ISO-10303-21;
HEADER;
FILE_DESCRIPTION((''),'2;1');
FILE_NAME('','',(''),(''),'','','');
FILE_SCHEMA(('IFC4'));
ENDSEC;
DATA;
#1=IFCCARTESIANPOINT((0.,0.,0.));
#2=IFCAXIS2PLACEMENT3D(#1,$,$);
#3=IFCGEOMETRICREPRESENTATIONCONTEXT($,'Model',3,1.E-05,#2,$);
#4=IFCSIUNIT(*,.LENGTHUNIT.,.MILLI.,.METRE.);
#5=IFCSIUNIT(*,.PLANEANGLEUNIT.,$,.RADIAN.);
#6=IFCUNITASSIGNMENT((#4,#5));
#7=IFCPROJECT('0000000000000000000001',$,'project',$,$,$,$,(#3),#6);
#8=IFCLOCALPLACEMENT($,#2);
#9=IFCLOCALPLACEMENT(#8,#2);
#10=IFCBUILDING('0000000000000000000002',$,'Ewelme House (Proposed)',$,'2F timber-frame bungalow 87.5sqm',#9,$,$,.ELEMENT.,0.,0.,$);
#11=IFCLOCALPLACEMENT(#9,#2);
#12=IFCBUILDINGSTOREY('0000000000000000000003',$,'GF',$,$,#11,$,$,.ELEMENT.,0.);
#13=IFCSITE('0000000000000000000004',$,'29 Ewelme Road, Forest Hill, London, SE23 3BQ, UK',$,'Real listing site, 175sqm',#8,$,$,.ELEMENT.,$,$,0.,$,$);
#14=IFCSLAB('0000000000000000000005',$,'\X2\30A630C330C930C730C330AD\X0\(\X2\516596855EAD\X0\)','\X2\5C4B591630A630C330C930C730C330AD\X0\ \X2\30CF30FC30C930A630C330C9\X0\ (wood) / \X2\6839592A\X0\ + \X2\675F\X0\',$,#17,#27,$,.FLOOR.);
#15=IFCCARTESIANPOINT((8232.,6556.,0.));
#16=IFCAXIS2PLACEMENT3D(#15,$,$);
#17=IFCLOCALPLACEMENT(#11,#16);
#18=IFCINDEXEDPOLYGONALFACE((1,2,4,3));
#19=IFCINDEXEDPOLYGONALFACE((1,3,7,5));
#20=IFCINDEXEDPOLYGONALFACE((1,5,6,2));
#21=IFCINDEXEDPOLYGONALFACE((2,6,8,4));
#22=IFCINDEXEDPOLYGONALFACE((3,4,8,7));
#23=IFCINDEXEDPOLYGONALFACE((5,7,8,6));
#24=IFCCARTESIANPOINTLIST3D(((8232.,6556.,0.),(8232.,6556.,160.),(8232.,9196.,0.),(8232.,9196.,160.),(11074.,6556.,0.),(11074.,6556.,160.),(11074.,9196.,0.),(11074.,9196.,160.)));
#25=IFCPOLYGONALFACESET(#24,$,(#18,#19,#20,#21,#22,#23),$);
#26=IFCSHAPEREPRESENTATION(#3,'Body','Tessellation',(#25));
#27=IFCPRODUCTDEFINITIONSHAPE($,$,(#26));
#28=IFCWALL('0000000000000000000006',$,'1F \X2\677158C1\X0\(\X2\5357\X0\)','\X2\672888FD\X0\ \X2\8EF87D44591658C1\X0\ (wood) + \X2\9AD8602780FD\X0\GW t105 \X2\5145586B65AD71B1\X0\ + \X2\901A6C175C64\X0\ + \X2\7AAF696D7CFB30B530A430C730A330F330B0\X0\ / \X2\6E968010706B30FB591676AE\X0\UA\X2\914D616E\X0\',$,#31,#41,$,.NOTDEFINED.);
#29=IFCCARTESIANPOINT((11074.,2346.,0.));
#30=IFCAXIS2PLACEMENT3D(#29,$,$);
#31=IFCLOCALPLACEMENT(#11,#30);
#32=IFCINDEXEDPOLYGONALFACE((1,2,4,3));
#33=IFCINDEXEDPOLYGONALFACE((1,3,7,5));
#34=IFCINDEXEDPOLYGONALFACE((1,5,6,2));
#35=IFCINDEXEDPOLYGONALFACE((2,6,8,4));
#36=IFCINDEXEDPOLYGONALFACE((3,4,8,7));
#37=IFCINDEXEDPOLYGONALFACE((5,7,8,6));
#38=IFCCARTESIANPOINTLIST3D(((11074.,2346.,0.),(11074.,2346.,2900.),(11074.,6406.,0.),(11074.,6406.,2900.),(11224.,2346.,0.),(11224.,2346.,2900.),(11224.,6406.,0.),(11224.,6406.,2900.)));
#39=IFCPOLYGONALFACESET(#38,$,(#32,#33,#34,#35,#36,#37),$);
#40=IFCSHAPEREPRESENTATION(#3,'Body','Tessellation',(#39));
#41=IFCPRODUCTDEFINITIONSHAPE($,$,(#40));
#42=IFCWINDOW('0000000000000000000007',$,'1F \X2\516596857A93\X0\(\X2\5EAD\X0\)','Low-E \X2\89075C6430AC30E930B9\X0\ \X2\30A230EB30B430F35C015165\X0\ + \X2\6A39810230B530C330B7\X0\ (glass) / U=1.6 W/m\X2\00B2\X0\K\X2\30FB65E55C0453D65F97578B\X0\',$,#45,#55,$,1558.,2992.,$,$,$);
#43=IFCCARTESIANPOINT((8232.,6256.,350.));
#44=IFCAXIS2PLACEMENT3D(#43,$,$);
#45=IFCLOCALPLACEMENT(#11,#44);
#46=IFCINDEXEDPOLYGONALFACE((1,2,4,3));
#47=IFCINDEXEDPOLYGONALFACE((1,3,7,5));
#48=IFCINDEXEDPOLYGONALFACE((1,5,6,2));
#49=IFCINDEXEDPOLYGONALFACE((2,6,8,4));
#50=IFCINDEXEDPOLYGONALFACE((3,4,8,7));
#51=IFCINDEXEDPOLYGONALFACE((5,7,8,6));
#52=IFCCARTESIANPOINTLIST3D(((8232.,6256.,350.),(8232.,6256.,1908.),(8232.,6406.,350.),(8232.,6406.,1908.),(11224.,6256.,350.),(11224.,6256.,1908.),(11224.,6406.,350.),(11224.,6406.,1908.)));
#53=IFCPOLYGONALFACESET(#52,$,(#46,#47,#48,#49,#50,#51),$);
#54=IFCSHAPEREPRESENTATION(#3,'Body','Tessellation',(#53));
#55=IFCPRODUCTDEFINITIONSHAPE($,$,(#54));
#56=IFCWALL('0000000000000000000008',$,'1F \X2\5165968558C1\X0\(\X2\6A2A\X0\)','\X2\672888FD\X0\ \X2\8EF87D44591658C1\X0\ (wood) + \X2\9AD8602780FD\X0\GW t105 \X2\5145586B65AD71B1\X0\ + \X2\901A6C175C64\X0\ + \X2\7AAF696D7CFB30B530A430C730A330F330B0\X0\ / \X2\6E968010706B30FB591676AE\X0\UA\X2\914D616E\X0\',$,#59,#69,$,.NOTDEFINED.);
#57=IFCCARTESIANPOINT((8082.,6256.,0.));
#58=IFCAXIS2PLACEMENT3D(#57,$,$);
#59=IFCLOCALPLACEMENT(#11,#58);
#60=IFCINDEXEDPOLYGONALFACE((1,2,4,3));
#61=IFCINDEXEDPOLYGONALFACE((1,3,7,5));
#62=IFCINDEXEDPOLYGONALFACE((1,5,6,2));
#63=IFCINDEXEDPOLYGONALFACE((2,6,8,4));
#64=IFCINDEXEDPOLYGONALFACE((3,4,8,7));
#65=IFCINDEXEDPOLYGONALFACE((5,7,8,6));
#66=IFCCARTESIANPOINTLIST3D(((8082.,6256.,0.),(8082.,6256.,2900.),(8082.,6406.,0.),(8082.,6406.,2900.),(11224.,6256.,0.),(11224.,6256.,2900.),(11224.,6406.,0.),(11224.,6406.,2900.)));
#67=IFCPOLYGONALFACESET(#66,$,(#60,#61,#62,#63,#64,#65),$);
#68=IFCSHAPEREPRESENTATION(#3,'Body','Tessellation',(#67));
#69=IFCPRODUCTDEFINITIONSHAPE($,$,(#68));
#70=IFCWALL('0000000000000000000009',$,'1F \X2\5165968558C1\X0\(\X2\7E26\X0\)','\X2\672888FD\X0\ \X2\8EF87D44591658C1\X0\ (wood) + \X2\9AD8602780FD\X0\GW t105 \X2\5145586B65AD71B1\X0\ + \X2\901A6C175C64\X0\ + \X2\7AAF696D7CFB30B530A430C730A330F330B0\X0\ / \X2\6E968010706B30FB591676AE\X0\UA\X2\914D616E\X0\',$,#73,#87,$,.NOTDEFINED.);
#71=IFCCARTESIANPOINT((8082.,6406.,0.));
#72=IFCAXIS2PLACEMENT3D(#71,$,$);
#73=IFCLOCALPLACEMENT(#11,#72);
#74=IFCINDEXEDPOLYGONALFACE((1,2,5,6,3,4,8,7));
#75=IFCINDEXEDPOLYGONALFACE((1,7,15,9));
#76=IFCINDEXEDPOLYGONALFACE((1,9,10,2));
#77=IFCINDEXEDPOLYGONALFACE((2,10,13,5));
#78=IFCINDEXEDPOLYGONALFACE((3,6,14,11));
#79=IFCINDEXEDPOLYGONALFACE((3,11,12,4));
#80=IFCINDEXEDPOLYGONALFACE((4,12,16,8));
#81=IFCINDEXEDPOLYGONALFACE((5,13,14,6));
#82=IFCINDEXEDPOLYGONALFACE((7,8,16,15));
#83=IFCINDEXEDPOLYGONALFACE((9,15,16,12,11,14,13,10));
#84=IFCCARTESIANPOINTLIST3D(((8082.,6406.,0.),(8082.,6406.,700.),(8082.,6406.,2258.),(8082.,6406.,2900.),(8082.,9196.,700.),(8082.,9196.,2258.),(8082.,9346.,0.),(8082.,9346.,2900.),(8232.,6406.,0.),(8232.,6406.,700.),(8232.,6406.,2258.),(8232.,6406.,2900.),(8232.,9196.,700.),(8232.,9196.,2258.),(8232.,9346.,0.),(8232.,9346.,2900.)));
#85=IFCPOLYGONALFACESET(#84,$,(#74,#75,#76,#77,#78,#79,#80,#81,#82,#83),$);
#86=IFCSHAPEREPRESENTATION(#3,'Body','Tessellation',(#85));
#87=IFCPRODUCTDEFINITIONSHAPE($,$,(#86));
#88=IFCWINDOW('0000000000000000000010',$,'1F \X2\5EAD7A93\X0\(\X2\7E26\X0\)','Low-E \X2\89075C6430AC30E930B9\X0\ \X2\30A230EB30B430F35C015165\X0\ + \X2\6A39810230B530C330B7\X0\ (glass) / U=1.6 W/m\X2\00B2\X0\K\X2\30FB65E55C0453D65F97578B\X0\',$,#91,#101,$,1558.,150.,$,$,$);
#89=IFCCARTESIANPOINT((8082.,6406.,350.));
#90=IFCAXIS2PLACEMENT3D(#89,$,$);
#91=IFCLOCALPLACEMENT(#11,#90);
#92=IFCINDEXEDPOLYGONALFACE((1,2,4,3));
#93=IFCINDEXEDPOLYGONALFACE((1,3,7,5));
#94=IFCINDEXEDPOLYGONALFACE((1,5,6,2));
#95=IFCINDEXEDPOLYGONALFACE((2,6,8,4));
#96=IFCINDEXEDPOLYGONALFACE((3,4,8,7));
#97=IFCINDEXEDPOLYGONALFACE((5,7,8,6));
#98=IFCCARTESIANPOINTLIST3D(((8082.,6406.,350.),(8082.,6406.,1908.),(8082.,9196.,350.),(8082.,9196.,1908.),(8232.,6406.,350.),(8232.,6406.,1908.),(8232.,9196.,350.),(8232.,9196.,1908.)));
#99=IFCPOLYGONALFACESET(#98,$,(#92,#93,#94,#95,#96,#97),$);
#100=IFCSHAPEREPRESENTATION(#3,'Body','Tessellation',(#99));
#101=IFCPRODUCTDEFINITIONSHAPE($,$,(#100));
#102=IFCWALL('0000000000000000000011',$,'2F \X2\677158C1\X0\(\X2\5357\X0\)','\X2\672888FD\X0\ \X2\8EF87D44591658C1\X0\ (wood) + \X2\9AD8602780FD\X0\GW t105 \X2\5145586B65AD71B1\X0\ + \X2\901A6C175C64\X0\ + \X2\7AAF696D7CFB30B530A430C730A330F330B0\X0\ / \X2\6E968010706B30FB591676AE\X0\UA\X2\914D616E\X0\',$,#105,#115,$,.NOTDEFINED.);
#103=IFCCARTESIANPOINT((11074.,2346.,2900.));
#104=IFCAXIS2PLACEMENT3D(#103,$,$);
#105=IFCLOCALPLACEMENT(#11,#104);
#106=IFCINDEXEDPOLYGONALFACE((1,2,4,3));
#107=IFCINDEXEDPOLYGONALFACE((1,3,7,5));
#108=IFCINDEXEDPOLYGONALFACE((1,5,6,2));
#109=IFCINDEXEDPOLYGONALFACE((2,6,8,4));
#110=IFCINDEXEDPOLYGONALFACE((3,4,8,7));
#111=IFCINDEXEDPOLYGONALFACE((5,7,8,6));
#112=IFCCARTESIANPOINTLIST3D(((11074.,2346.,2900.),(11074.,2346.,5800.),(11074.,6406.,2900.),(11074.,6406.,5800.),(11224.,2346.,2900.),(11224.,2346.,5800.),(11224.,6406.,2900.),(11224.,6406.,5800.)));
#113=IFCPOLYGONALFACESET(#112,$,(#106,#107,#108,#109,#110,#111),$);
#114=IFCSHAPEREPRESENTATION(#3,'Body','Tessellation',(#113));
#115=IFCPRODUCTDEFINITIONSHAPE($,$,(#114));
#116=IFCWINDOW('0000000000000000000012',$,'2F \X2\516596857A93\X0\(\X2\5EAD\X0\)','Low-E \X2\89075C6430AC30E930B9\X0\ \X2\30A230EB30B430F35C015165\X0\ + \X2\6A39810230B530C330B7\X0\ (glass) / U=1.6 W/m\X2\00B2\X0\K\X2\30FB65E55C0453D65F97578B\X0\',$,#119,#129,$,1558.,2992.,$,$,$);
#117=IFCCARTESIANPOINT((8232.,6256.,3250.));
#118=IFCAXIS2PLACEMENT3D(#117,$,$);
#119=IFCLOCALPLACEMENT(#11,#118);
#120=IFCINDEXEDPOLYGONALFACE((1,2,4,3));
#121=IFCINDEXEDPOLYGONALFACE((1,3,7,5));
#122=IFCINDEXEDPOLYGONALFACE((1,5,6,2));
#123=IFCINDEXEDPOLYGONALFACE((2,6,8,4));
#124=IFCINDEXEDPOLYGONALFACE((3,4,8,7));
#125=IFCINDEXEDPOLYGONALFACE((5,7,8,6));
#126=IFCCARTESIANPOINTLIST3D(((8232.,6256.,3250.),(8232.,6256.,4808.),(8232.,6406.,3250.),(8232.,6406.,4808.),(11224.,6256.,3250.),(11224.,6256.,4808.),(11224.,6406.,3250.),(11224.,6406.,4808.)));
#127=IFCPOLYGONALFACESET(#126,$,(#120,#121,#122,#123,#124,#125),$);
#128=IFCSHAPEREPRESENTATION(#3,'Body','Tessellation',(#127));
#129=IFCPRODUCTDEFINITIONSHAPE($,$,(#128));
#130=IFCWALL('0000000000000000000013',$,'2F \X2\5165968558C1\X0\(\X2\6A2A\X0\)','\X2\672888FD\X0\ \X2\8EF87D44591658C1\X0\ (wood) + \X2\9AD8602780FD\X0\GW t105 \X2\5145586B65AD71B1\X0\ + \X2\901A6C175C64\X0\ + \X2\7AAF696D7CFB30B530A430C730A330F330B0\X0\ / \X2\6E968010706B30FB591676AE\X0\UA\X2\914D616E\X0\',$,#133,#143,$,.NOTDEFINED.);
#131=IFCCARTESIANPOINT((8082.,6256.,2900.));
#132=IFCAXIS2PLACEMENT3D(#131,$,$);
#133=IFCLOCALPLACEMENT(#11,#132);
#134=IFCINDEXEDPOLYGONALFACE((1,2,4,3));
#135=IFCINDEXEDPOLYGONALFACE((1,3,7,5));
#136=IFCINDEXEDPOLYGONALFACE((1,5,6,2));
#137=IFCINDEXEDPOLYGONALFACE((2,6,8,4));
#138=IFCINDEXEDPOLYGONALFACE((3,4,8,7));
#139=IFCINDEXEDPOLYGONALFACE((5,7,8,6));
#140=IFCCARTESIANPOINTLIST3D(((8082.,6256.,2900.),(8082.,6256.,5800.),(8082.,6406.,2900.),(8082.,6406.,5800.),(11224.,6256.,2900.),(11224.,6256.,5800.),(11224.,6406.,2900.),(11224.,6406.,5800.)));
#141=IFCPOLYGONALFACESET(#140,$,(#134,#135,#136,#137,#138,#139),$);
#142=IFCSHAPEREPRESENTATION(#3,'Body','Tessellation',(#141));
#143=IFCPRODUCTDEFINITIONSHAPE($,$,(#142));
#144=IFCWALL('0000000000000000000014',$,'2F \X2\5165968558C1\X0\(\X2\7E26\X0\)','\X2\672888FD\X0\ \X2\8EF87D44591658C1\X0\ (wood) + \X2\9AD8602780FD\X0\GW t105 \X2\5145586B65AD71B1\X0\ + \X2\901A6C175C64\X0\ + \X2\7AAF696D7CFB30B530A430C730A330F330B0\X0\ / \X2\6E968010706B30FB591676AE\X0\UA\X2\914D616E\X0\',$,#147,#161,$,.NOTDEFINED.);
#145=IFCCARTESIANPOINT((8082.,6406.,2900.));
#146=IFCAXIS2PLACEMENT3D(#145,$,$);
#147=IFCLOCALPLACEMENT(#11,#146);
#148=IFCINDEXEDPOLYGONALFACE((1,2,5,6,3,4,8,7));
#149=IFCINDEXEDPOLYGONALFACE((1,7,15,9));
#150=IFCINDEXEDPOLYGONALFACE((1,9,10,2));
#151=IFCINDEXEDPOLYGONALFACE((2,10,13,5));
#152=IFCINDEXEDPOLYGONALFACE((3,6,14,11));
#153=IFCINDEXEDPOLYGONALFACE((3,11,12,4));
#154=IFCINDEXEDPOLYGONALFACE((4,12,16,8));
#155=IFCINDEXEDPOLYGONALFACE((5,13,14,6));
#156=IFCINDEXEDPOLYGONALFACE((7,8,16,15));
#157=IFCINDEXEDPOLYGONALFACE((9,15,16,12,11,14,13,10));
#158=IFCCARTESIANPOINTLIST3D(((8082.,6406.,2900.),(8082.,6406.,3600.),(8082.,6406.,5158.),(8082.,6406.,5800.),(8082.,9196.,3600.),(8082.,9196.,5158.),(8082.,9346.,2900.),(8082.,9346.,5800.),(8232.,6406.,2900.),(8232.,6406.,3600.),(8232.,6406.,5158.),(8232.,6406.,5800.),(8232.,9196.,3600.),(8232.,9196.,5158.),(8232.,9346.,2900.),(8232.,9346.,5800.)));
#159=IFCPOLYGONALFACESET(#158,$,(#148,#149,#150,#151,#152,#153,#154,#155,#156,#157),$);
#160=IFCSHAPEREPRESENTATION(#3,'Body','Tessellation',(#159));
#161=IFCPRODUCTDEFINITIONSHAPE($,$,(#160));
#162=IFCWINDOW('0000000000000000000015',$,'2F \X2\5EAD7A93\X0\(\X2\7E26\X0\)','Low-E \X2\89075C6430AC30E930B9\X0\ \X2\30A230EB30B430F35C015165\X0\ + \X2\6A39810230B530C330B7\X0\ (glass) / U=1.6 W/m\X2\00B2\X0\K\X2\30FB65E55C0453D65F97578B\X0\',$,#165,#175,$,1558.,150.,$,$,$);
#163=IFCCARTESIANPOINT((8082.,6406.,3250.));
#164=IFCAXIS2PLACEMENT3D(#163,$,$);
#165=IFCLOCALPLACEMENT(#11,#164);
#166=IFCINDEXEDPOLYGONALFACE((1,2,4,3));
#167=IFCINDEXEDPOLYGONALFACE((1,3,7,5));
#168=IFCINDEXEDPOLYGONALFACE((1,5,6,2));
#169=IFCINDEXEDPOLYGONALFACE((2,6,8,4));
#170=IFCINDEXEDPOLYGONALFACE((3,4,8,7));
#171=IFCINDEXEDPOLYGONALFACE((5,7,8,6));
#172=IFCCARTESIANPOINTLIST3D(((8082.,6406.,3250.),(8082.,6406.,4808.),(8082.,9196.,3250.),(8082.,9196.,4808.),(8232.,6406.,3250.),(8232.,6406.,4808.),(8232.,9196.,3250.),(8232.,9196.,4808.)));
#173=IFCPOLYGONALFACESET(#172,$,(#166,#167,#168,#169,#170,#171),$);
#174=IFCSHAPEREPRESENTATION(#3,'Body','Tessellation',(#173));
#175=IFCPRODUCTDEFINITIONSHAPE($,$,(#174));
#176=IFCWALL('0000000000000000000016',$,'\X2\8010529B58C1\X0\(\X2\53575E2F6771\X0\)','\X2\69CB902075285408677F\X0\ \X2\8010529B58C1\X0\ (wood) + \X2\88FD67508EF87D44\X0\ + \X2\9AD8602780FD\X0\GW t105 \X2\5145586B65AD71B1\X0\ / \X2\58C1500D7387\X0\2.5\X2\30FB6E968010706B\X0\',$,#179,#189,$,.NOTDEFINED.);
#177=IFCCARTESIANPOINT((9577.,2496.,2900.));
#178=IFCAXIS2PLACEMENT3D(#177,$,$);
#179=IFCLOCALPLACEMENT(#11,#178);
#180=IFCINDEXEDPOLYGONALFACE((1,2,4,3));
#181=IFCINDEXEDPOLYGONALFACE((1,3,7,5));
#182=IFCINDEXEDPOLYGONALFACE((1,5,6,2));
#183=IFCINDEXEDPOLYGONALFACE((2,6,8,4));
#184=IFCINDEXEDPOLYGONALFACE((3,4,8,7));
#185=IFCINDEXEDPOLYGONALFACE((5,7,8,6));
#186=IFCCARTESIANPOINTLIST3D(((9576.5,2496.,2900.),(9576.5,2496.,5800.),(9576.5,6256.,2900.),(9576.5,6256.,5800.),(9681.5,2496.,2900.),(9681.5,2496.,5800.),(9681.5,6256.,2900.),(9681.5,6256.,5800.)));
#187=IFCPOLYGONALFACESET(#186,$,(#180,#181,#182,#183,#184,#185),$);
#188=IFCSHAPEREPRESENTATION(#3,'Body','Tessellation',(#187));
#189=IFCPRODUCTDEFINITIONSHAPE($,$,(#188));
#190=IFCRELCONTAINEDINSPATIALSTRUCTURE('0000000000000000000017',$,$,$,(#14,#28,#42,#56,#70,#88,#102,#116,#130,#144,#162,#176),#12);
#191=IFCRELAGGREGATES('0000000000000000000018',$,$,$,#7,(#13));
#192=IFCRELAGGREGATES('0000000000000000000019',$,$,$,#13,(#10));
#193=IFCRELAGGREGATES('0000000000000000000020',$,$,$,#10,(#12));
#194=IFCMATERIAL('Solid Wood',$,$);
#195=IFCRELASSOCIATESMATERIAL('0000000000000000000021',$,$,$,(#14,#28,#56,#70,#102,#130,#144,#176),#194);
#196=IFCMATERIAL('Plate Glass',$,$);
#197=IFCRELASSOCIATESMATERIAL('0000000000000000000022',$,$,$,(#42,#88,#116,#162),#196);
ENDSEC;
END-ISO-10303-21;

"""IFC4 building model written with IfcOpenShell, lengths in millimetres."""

from ifc_helpers import new_model, si_unit, frame, frame_2d, origin, place, context, project, spatial, rectangle, extrude, material, element, fill, save


model = new_model("IFC4")

# Units and contexts
model_context = context("Model", 3, precision=1e-05, world=origin())
ifc_project = project(units=[si_unit("LENGTHUNIT", "METRE", prefix="MILLI"), si_unit("PLANEANGLEUNIT", "RADIAN")], contexts=[model_context])

# Site, building, storey
site_placement = place(None, origin())
site = spatial("IfcSite", under=ifc_project, at=site_placement, Name="29 Ewelme Road, Forest Hill, London, SE23 3BQ, UK", ObjectType="Real listing site, 175sqm", CompositionType="ELEMENT", RefElevation=0.0)
building_placement = place(site_placement, origin())
building = spatial("IfcBuilding", under=site, at=building_placement, Name="Ewelme House (Proposed)", ObjectType="2F timber-frame bungalow 87.5sqm", CompositionType="ELEMENT", ElevationOfRefHeight=0.0, ElevationOfTerrain=0.0)
storey_placement = place(building_placement, origin())
storey = spatial("IfcBuildingStorey", under=building, at=storey_placement, Name="GF", CompositionType="ELEMENT", Elevation=0.0)

# Slab
ifc_material_1 = material(Name="Solid Wood")
slab_placement = place(storey_placement, frame((8232.0, 6556.0, 0.0)))
element("IfcSlab", 1, at=slab_placement, inside=storey, material=ifc_material_1, Name="ウッドデッキ(入隅庭)", Description="屋外ウッドデッキ ハードウッド (wood) / 根太 + 束", PredefinedType="FLOOR", context=model_context, shape_type="SweptSolid", body=[
    extrude(rectangle(XDim=2842.0, YDim=2640.0, at=frame_2d((1421.0, 1320.0))), frame((8232.0, 6556.0, 0.0)), (0.0, 0.0, 1.0), 160.0),
])

# Wall, opening, window
wall_1_placement = place(storey_placement, frame((11074.0, 2346.0, 0.0)))
wall_1 = element("IfcWall", 2, at=wall_1_placement, inside=storey, material=ifc_material_1, Name="1F 東壁(南)", Description="木製 軸組外壁 (wood) + 高性能GW t105 充填断熱 + 通気層 + 窯業系サイディング / 準耐火・外皮UA配慮", PredefinedType="NOTDEFINED", context=model_context, shape_type="SweptSolid", body=[
    extrude(rectangle(XDim=150.0, YDim=4060.0, at=frame_2d((75.0, 2030.0))), frame((11074.0, 2346.0, 0.0)), (0.0, 0.0, 1.0), 2900.0),
])
opening_1_placement = place(storey_placement, frame((8232.0, 6256.0, 350.0)))
opening_1 = element("IfcOpeningElement", 3, at=opening_1_placement, cuts=wall_1, PredefinedType="NOTDEFINED", context=model_context, shape_type="SweptSolid", body=[
    extrude(rectangle(XDim=2992.0, YDim=150.0, at=frame_2d((1496.0, 75.0))), frame((8232.0, 6256.0, 350.0)), (0.0, 0.0, 1.0), 1558.0),
])
ifc_material_2 = material(Name="Plate Glass")
window_1_placement = place(storey_placement, frame((8232.0, 6256.0, 350.0)))
window_1 = element("IfcWindow", 4, at=window_1_placement, inside=storey, material=ifc_material_2, Name="1F 入隅窓(庭)", Description="Low-E 複層ガラス アルゴン封入 + 樹脂サッシ (glass) / U=1.6 W/m²K・日射取得型", OverallHeight=1558.0, OverallWidth=2992.0, context=model_context, shape_type="SweptSolid", body=[
    extrude(rectangle(XDim=2992.0, YDim=150.0, at=frame_2d((1496.0, 75.0))), frame((8232.0, 6256.0, 350.0)), (0.0, 0.0, 1.0), 1558.0),
])
fill(opening_1, window_1)

# Wall
wall_2_placement = place(storey_placement, frame((8082.0, 6256.0, 0.0)))
element("IfcWall", 5, at=wall_2_placement, inside=storey, material=ifc_material_1, Name="1F 入隅壁(横)", Description="木製 軸組外壁 (wood) + 高性能GW t105 充填断熱 + 通気層 + 窯業系サイディング / 準耐火・外皮UA配慮", PredefinedType="NOTDEFINED", context=model_context, shape_type="SweptSolid", body=[
    extrude(rectangle(XDim=3142.0, YDim=150.0, at=frame_2d((1571.0, 75.0))), frame((8082.0, 6256.0, 0.0)), (0.0, 0.0, 1.0), 2900.0),
])

# Wall, opening, window
wall_3_placement = place(storey_placement, frame((8082.0, 6406.0, 0.0)))
wall_3 = element("IfcWall", 6, at=wall_3_placement, inside=storey, material=ifc_material_1, Name="1F 入隅壁(縦)", Description="木製 軸組外壁 (wood) + 高性能GW t105 充填断熱 + 通気層 + 窯業系サイディング / 準耐火・外皮UA配慮", PredefinedType="NOTDEFINED", context=model_context, shape_type="SweptSolid", body=[
    extrude(rectangle(XDim=150.0, YDim=2940.0, at=frame_2d((75.0, 1470.0))), frame((8082.0, 6406.0, 0.0)), (0.0, 0.0, 1.0), 2900.0),
])
opening_2_placement = place(storey_placement, frame((8082.0, 6406.0, 350.0)))
opening_2 = element("IfcOpeningElement", 7, at=opening_2_placement, cuts=wall_3, PredefinedType="NOTDEFINED", context=model_context, shape_type="SweptSolid", body=[
    extrude(rectangle(XDim=150.0, YDim=2790.0, at=frame_2d((75.0, 1395.0))), frame((8082.0, 6406.0, 350.0)), (0.0, 0.0, 1.0), 1558.0),
])
window_2_placement = place(storey_placement, frame((8082.0, 6406.0, 350.0)))
window_2 = element("IfcWindow", 8, at=window_2_placement, inside=storey, material=ifc_material_2, Name="1F 庭窓(縦)", Description="Low-E 複層ガラス アルゴン封入 + 樹脂サッシ (glass) / U=1.6 W/m²K・日射取得型", OverallHeight=1558.0, OverallWidth=150.0, context=model_context, shape_type="SweptSolid", body=[
    extrude(rectangle(XDim=150.0, YDim=2790.0, at=frame_2d((75.0, 1395.0))), frame((8082.0, 6406.0, 350.0)), (0.0, 0.0, 1.0), 1558.0),
])
fill(opening_2, window_2)

# Wall, opening, window
wall_4_placement = place(storey_placement, frame((11074.0, 2346.0, 2900.0)))
wall_4 = element("IfcWall", 9, at=wall_4_placement, inside=storey, material=ifc_material_1, Name="2F 東壁(南)", Description="木製 軸組外壁 (wood) + 高性能GW t105 充填断熱 + 通気層 + 窯業系サイディング / 準耐火・外皮UA配慮", PredefinedType="NOTDEFINED", context=model_context, shape_type="SweptSolid", body=[
    extrude(rectangle(XDim=150.0, YDim=4060.0, at=frame_2d((75.0, 2030.0))), frame((11074.0, 2346.0, 2900.0)), (0.0, 0.0, 1.0), 2900.0),
])
opening_3_placement = place(storey_placement, frame((8232.0, 6256.0, 3250.0)))
opening_3 = element("IfcOpeningElement", 10, at=opening_3_placement, cuts=wall_4, PredefinedType="NOTDEFINED", context=model_context, shape_type="SweptSolid", body=[
    extrude(rectangle(XDim=2992.0, YDim=150.0, at=frame_2d((1496.0, 75.0))), frame((8232.0, 6256.0, 3250.0)), (0.0, 0.0, 1.0), 1558.0),
])
window_3_placement = place(storey_placement, frame((8232.0, 6256.0, 3250.0)))
window_3 = element("IfcWindow", 11, at=window_3_placement, inside=storey, material=ifc_material_2, Name="2F 入隅窓(庭)", Description="Low-E 複層ガラス アルゴン封入 + 樹脂サッシ (glass) / U=1.6 W/m²K・日射取得型", OverallHeight=1558.0, OverallWidth=2992.0, context=model_context, shape_type="SweptSolid", body=[
    extrude(rectangle(XDim=2992.0, YDim=150.0, at=frame_2d((1496.0, 75.0))), frame((8232.0, 6256.0, 3250.0)), (0.0, 0.0, 1.0), 1558.0),
])
fill(opening_3, window_3)

# Wall
wall_5_placement = place(storey_placement, frame((8082.0, 6256.0, 2900.0)))
element("IfcWall", 12, at=wall_5_placement, inside=storey, material=ifc_material_1, Name="2F 入隅壁(横)", Description="木製 軸組外壁 (wood) + 高性能GW t105 充填断熱 + 通気層 + 窯業系サイディング / 準耐火・外皮UA配慮", PredefinedType="NOTDEFINED", context=model_context, shape_type="SweptSolid", body=[
    extrude(rectangle(XDim=3142.0, YDim=150.0, at=frame_2d((1571.0, 75.0))), frame((8082.0, 6256.0, 2900.0)), (0.0, 0.0, 1.0), 2900.0),
])

# Wall, opening, window
wall_6_placement = place(storey_placement, frame((8082.0, 6406.0, 2900.0)))
wall_6 = element("IfcWall", 13, at=wall_6_placement, inside=storey, material=ifc_material_1, Name="2F 入隅壁(縦)", Description="木製 軸組外壁 (wood) + 高性能GW t105 充填断熱 + 通気層 + 窯業系サイディング / 準耐火・外皮UA配慮", PredefinedType="NOTDEFINED", context=model_context, shape_type="SweptSolid", body=[
    extrude(rectangle(XDim=150.0, YDim=2940.0, at=frame_2d((75.0, 1470.0))), frame((8082.0, 6406.0, 2900.0)), (0.0, 0.0, 1.0), 2900.0),
])
opening_4_placement = place(storey_placement, frame((8082.0, 6406.0, 3250.0)))
opening_4 = element("IfcOpeningElement", 14, at=opening_4_placement, cuts=wall_6, PredefinedType="NOTDEFINED", context=model_context, shape_type="SweptSolid", body=[
    extrude(rectangle(XDim=150.0, YDim=2790.0, at=frame_2d((75.0, 1395.0))), frame((8082.0, 6406.0, 3250.0)), (0.0, 0.0, 1.0), 1558.0),
])
window_4_placement = place(storey_placement, frame((8082.0, 6406.0, 3250.0)))
window_4 = element("IfcWindow", 15, at=window_4_placement, inside=storey, material=ifc_material_2, Name="2F 庭窓(縦)", Description="Low-E 複層ガラス アルゴン封入 + 樹脂サッシ (glass) / U=1.6 W/m²K・日射取得型", OverallHeight=1558.0, OverallWidth=150.0, context=model_context, shape_type="SweptSolid", body=[
    extrude(rectangle(XDim=150.0, YDim=2790.0, at=frame_2d((75.0, 1395.0))), frame((8082.0, 6406.0, 3250.0)), (0.0, 0.0, 1.0), 1558.0),
])
fill(opening_4, window_4)

# Wall
wall_7_placement = place(storey_placement, frame((9577.0, 2496.0, 2900.0)))
element("IfcWall", 16, at=wall_7_placement, inside=storey, material=ifc_material_1, Name="耐力壁(南帯東)", Description="構造用合板 耐力壁 (wood) + 製材軸組 + 高性能GW t105 充填断熱 / 壁倍率2.5・準耐火", PredefinedType="NOTDEFINED", context=model_context, shape_type="SweptSolid", body=[
    extrude(rectangle(XDim=105.0, YDim=3760.0, at=frame_2d((52.0, 1880.0))), frame((9577.0, 2496.0, 2900.0)), (0.0, 0.0, 1.0), 2900.0),
])

save(model, "model.ifc")
